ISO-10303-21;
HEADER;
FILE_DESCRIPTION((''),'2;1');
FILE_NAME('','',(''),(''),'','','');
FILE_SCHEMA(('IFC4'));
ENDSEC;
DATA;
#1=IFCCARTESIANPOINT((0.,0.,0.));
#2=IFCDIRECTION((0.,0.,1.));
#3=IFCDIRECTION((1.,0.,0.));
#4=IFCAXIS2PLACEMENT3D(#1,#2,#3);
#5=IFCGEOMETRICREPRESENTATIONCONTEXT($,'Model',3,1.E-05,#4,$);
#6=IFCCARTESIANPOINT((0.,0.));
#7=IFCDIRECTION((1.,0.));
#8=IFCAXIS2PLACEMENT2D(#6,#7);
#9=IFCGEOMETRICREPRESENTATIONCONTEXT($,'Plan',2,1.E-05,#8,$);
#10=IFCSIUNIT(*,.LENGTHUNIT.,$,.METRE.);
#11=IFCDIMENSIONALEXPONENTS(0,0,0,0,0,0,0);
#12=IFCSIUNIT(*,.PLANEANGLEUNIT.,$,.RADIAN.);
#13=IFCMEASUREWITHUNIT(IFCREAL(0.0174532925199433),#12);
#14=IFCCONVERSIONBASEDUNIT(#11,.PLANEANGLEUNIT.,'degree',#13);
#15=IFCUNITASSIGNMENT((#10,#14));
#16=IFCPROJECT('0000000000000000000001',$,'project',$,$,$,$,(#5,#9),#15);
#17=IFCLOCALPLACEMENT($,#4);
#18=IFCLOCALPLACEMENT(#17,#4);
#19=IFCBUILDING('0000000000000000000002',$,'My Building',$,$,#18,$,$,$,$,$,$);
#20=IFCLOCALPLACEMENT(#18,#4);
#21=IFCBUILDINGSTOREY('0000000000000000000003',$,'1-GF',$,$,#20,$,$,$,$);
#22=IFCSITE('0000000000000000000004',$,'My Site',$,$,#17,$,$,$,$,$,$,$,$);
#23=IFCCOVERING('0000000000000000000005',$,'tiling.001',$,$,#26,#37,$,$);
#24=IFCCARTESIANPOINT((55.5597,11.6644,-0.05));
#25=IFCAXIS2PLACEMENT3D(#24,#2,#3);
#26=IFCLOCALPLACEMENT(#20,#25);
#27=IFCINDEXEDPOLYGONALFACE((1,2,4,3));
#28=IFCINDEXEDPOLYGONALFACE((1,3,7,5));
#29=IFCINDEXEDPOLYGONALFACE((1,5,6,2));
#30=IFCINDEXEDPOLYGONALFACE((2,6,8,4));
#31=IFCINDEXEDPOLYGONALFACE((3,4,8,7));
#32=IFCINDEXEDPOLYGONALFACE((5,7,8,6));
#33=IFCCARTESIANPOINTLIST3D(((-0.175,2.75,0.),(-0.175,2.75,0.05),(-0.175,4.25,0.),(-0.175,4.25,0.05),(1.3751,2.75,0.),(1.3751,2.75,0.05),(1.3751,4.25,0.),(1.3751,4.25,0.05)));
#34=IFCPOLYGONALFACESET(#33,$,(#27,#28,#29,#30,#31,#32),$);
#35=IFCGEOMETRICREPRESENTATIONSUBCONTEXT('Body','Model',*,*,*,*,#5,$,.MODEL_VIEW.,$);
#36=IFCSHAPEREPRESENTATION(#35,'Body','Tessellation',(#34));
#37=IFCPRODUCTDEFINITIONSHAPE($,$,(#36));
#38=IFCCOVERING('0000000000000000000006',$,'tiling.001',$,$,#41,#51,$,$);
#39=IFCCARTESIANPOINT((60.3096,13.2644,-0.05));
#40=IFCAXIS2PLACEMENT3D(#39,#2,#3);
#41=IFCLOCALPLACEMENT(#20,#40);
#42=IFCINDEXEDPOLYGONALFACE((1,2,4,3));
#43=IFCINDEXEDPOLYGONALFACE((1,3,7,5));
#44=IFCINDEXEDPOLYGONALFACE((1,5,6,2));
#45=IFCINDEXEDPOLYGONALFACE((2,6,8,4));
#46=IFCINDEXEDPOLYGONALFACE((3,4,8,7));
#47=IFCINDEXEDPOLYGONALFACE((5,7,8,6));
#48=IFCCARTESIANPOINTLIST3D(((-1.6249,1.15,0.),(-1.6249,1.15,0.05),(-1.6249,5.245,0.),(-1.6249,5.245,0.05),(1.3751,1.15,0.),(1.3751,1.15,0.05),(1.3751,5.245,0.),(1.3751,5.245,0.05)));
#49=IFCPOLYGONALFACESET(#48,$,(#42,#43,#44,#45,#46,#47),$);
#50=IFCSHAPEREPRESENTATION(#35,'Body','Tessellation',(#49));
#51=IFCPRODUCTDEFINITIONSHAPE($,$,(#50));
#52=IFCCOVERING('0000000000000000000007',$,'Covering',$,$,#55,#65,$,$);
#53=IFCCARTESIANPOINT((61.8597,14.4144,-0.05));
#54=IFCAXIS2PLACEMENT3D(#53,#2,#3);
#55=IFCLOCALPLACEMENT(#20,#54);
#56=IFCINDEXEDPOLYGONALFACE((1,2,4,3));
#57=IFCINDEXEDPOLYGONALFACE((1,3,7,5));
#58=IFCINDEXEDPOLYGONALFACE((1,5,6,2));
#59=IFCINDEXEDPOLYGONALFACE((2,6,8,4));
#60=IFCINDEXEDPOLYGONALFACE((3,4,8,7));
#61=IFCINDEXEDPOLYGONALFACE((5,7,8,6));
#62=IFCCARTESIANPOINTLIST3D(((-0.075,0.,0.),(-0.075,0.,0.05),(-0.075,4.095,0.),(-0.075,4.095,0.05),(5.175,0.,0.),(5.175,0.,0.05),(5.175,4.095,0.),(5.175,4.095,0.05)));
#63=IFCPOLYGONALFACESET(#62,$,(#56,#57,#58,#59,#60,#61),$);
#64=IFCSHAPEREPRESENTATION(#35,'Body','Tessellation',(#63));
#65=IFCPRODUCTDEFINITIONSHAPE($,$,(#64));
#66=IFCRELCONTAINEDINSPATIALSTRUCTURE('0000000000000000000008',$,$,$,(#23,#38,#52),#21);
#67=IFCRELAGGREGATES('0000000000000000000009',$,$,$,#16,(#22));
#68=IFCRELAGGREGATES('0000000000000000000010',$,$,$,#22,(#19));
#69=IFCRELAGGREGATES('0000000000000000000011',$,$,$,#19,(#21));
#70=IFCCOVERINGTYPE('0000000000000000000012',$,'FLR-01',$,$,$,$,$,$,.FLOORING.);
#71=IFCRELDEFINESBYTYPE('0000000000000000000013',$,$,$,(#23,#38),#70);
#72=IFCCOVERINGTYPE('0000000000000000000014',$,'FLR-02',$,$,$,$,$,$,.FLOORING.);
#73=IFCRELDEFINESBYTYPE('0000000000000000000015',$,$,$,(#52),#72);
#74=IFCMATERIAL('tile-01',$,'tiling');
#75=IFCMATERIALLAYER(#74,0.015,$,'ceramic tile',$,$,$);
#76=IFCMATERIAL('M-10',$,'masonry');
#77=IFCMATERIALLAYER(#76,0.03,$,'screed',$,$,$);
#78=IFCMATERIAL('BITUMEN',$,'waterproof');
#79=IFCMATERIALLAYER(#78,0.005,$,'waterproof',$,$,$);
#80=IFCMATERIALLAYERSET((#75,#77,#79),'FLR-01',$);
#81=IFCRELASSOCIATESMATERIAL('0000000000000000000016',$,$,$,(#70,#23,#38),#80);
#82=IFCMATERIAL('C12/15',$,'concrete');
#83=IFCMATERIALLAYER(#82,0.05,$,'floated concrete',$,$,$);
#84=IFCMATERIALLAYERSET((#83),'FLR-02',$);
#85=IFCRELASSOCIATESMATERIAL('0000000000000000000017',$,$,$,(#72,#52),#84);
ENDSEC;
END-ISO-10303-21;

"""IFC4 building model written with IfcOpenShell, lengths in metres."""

from ifc_helpers import new_model, entity, si_unit, converted_unit, frame, origin_with_axes, origin_2d_with_axis, place, context, subcontext, project, spatial, line, indexed_curve, outline, extrude, material, layer, layer_set, layer_usage, type_object, element, save


model = new_model("IFC4")

# Units and contexts
model_context = context("Model", 3, precision=1e-05, world=origin_with_axes())
plan_context = context("Plan", 2, precision=1e-05, world=origin_2d_with_axis())
body_context_1 = subcontext(model_context, "Body", "Model", "MODEL_VIEW")
ifc_project = project(units=[si_unit("LENGTHUNIT", "METRE"), converted_unit("PLANEANGLEUNIT", "degree", entity("IfcReal", 0.0174532925199433), si_unit("PLANEANGLEUNIT", "RADIAN"), dimensions=[0, 0, 0, 0, 0, 0, 0])], contexts=[model_context, plan_context])

# Site, building, storey
site_placement = place(None, origin_with_axes())
site = spatial("IfcSite", under=ifc_project, at=site_placement, Name="My Site")
building_placement = place(site_placement, origin_with_axes())
building = spatial("IfcBuilding", under=site, at=building_placement, Name="My Building")
storey_placement = place(building_placement, origin_with_axes())
storey = spatial("IfcBuildingStorey", under=building, at=storey_placement, Name="1-GF")

# Coverings
ifc_material_1 = material(Name="C12/15", Category="concrete")
ifc_material_2 = material(Name="tile-01", Category="tiling")
ifc_layer_1 = layer(ifc_material_2, 0.015, Name="ceramic tile")
ifc_material_3 = material(Name="M-10", Category="masonry")
ifc_layer_2 = layer(ifc_material_3, 0.03, Name="screed")
ifc_material_4 = material(Name="BITUMEN", Category="waterproof")
ifc_layer_3 = layer(ifc_material_4, 0.005, Name="waterproof")
ifc_layer_set_1 = layer_set([ifc_layer_1, ifc_layer_2, ifc_layer_3], Name="FLR-01")
covering_type_1 = type_object("IfcCoveringType", Name="FLR-01", PredefinedType="FLOORING", material=ifc_layer_set_1)
ifc_layer_usage_1 = layer_usage(ifc_layer_set_1, "AXIS3", "POSITIVE", 0.0)
covering_1_placement = place(storey_placement, frame((55.5597, 11.6644, -0.05), z_axis=(0.0, 0.0, 1.0), x_axis=(1.0, 0.0, 0.0)))
element("IfcCovering", 1, at=covering_1_placement, inside=storey, type_object=covering_type_1, material=ifc_layer_usage_1, Name="tiling.001", context=body_context_1, shape_type="SweptSolid", body=[
    extrude(outline(indexed_curve([(1.3751, 4.25), (-0.175, 4.25), (-0.175, 2.75), (1.3751, 2.75)], segments=[line(3, 2), line(2, 1), line(1, 4), line(4, 3)], self_intersect=False)), None, (0.0, 0.0, 1.0), 0.05),
])
ifc_layer_usage_2 = layer_usage(ifc_layer_set_1, "AXIS3", "POSITIVE", 0.0)
covering_2_placement = place(storey_placement, frame((60.3096, 13.2644, -0.05), z_axis=(0.0, 0.0, 1.0), x_axis=(1.0, 0.0, 0.0)))
element("IfcCovering", 2, at=covering_2_placement, inside=storey, type_object=covering_type_1, material=ifc_layer_usage_2, Name="tiling.001", context=body_context_1, shape_type="SweptSolid", body=[
    extrude(outline(indexed_curve([(1.3751, 5.245), (-1.6249, 5.245), (-1.6249, 1.15), (1.3751, 1.15)], segments=[line(3, 2), line(2, 1), line(1, 4), line(4, 3)], self_intersect=False)), None, (0.0, 0.0, 1.0), 0.05),
])
ifc_layer_4 = layer(ifc_material_1, 0.05, Name="floated concrete")
ifc_layer_set_2 = layer_set([ifc_layer_4], Name="FLR-02")
ifc_layer_usage_3 = layer_usage(ifc_layer_set_2, "AXIS3", "POSITIVE", 0.0)
covering_type_2 = type_object("IfcCoveringType", Name="FLR-02", PredefinedType="FLOORING", material=ifc_layer_set_2)
covering_3_placement = place(storey_placement, frame((61.8597, 14.4144, -0.05), z_axis=(0.0, 0.0, 1.0), x_axis=(1.0, 0.0, 0.0)))
element("IfcCovering", 3, at=covering_3_placement, inside=storey, type_object=covering_type_2, material=ifc_layer_usage_3, Name="Covering", context=body_context_1, shape_type="SweptSolid", body=[
    extrude(outline(indexed_curve([(5.175, 4.095), (5.175, 0.0), (-0.075, 0.0), (-0.075, 4.095)], segments=[line(3, 2), line(2, 1), line(1, 4), line(4, 3)], self_intersect=False)), None, (0.0, 0.0, 1.0), 0.05),
])

save(model, "model.ifc")
